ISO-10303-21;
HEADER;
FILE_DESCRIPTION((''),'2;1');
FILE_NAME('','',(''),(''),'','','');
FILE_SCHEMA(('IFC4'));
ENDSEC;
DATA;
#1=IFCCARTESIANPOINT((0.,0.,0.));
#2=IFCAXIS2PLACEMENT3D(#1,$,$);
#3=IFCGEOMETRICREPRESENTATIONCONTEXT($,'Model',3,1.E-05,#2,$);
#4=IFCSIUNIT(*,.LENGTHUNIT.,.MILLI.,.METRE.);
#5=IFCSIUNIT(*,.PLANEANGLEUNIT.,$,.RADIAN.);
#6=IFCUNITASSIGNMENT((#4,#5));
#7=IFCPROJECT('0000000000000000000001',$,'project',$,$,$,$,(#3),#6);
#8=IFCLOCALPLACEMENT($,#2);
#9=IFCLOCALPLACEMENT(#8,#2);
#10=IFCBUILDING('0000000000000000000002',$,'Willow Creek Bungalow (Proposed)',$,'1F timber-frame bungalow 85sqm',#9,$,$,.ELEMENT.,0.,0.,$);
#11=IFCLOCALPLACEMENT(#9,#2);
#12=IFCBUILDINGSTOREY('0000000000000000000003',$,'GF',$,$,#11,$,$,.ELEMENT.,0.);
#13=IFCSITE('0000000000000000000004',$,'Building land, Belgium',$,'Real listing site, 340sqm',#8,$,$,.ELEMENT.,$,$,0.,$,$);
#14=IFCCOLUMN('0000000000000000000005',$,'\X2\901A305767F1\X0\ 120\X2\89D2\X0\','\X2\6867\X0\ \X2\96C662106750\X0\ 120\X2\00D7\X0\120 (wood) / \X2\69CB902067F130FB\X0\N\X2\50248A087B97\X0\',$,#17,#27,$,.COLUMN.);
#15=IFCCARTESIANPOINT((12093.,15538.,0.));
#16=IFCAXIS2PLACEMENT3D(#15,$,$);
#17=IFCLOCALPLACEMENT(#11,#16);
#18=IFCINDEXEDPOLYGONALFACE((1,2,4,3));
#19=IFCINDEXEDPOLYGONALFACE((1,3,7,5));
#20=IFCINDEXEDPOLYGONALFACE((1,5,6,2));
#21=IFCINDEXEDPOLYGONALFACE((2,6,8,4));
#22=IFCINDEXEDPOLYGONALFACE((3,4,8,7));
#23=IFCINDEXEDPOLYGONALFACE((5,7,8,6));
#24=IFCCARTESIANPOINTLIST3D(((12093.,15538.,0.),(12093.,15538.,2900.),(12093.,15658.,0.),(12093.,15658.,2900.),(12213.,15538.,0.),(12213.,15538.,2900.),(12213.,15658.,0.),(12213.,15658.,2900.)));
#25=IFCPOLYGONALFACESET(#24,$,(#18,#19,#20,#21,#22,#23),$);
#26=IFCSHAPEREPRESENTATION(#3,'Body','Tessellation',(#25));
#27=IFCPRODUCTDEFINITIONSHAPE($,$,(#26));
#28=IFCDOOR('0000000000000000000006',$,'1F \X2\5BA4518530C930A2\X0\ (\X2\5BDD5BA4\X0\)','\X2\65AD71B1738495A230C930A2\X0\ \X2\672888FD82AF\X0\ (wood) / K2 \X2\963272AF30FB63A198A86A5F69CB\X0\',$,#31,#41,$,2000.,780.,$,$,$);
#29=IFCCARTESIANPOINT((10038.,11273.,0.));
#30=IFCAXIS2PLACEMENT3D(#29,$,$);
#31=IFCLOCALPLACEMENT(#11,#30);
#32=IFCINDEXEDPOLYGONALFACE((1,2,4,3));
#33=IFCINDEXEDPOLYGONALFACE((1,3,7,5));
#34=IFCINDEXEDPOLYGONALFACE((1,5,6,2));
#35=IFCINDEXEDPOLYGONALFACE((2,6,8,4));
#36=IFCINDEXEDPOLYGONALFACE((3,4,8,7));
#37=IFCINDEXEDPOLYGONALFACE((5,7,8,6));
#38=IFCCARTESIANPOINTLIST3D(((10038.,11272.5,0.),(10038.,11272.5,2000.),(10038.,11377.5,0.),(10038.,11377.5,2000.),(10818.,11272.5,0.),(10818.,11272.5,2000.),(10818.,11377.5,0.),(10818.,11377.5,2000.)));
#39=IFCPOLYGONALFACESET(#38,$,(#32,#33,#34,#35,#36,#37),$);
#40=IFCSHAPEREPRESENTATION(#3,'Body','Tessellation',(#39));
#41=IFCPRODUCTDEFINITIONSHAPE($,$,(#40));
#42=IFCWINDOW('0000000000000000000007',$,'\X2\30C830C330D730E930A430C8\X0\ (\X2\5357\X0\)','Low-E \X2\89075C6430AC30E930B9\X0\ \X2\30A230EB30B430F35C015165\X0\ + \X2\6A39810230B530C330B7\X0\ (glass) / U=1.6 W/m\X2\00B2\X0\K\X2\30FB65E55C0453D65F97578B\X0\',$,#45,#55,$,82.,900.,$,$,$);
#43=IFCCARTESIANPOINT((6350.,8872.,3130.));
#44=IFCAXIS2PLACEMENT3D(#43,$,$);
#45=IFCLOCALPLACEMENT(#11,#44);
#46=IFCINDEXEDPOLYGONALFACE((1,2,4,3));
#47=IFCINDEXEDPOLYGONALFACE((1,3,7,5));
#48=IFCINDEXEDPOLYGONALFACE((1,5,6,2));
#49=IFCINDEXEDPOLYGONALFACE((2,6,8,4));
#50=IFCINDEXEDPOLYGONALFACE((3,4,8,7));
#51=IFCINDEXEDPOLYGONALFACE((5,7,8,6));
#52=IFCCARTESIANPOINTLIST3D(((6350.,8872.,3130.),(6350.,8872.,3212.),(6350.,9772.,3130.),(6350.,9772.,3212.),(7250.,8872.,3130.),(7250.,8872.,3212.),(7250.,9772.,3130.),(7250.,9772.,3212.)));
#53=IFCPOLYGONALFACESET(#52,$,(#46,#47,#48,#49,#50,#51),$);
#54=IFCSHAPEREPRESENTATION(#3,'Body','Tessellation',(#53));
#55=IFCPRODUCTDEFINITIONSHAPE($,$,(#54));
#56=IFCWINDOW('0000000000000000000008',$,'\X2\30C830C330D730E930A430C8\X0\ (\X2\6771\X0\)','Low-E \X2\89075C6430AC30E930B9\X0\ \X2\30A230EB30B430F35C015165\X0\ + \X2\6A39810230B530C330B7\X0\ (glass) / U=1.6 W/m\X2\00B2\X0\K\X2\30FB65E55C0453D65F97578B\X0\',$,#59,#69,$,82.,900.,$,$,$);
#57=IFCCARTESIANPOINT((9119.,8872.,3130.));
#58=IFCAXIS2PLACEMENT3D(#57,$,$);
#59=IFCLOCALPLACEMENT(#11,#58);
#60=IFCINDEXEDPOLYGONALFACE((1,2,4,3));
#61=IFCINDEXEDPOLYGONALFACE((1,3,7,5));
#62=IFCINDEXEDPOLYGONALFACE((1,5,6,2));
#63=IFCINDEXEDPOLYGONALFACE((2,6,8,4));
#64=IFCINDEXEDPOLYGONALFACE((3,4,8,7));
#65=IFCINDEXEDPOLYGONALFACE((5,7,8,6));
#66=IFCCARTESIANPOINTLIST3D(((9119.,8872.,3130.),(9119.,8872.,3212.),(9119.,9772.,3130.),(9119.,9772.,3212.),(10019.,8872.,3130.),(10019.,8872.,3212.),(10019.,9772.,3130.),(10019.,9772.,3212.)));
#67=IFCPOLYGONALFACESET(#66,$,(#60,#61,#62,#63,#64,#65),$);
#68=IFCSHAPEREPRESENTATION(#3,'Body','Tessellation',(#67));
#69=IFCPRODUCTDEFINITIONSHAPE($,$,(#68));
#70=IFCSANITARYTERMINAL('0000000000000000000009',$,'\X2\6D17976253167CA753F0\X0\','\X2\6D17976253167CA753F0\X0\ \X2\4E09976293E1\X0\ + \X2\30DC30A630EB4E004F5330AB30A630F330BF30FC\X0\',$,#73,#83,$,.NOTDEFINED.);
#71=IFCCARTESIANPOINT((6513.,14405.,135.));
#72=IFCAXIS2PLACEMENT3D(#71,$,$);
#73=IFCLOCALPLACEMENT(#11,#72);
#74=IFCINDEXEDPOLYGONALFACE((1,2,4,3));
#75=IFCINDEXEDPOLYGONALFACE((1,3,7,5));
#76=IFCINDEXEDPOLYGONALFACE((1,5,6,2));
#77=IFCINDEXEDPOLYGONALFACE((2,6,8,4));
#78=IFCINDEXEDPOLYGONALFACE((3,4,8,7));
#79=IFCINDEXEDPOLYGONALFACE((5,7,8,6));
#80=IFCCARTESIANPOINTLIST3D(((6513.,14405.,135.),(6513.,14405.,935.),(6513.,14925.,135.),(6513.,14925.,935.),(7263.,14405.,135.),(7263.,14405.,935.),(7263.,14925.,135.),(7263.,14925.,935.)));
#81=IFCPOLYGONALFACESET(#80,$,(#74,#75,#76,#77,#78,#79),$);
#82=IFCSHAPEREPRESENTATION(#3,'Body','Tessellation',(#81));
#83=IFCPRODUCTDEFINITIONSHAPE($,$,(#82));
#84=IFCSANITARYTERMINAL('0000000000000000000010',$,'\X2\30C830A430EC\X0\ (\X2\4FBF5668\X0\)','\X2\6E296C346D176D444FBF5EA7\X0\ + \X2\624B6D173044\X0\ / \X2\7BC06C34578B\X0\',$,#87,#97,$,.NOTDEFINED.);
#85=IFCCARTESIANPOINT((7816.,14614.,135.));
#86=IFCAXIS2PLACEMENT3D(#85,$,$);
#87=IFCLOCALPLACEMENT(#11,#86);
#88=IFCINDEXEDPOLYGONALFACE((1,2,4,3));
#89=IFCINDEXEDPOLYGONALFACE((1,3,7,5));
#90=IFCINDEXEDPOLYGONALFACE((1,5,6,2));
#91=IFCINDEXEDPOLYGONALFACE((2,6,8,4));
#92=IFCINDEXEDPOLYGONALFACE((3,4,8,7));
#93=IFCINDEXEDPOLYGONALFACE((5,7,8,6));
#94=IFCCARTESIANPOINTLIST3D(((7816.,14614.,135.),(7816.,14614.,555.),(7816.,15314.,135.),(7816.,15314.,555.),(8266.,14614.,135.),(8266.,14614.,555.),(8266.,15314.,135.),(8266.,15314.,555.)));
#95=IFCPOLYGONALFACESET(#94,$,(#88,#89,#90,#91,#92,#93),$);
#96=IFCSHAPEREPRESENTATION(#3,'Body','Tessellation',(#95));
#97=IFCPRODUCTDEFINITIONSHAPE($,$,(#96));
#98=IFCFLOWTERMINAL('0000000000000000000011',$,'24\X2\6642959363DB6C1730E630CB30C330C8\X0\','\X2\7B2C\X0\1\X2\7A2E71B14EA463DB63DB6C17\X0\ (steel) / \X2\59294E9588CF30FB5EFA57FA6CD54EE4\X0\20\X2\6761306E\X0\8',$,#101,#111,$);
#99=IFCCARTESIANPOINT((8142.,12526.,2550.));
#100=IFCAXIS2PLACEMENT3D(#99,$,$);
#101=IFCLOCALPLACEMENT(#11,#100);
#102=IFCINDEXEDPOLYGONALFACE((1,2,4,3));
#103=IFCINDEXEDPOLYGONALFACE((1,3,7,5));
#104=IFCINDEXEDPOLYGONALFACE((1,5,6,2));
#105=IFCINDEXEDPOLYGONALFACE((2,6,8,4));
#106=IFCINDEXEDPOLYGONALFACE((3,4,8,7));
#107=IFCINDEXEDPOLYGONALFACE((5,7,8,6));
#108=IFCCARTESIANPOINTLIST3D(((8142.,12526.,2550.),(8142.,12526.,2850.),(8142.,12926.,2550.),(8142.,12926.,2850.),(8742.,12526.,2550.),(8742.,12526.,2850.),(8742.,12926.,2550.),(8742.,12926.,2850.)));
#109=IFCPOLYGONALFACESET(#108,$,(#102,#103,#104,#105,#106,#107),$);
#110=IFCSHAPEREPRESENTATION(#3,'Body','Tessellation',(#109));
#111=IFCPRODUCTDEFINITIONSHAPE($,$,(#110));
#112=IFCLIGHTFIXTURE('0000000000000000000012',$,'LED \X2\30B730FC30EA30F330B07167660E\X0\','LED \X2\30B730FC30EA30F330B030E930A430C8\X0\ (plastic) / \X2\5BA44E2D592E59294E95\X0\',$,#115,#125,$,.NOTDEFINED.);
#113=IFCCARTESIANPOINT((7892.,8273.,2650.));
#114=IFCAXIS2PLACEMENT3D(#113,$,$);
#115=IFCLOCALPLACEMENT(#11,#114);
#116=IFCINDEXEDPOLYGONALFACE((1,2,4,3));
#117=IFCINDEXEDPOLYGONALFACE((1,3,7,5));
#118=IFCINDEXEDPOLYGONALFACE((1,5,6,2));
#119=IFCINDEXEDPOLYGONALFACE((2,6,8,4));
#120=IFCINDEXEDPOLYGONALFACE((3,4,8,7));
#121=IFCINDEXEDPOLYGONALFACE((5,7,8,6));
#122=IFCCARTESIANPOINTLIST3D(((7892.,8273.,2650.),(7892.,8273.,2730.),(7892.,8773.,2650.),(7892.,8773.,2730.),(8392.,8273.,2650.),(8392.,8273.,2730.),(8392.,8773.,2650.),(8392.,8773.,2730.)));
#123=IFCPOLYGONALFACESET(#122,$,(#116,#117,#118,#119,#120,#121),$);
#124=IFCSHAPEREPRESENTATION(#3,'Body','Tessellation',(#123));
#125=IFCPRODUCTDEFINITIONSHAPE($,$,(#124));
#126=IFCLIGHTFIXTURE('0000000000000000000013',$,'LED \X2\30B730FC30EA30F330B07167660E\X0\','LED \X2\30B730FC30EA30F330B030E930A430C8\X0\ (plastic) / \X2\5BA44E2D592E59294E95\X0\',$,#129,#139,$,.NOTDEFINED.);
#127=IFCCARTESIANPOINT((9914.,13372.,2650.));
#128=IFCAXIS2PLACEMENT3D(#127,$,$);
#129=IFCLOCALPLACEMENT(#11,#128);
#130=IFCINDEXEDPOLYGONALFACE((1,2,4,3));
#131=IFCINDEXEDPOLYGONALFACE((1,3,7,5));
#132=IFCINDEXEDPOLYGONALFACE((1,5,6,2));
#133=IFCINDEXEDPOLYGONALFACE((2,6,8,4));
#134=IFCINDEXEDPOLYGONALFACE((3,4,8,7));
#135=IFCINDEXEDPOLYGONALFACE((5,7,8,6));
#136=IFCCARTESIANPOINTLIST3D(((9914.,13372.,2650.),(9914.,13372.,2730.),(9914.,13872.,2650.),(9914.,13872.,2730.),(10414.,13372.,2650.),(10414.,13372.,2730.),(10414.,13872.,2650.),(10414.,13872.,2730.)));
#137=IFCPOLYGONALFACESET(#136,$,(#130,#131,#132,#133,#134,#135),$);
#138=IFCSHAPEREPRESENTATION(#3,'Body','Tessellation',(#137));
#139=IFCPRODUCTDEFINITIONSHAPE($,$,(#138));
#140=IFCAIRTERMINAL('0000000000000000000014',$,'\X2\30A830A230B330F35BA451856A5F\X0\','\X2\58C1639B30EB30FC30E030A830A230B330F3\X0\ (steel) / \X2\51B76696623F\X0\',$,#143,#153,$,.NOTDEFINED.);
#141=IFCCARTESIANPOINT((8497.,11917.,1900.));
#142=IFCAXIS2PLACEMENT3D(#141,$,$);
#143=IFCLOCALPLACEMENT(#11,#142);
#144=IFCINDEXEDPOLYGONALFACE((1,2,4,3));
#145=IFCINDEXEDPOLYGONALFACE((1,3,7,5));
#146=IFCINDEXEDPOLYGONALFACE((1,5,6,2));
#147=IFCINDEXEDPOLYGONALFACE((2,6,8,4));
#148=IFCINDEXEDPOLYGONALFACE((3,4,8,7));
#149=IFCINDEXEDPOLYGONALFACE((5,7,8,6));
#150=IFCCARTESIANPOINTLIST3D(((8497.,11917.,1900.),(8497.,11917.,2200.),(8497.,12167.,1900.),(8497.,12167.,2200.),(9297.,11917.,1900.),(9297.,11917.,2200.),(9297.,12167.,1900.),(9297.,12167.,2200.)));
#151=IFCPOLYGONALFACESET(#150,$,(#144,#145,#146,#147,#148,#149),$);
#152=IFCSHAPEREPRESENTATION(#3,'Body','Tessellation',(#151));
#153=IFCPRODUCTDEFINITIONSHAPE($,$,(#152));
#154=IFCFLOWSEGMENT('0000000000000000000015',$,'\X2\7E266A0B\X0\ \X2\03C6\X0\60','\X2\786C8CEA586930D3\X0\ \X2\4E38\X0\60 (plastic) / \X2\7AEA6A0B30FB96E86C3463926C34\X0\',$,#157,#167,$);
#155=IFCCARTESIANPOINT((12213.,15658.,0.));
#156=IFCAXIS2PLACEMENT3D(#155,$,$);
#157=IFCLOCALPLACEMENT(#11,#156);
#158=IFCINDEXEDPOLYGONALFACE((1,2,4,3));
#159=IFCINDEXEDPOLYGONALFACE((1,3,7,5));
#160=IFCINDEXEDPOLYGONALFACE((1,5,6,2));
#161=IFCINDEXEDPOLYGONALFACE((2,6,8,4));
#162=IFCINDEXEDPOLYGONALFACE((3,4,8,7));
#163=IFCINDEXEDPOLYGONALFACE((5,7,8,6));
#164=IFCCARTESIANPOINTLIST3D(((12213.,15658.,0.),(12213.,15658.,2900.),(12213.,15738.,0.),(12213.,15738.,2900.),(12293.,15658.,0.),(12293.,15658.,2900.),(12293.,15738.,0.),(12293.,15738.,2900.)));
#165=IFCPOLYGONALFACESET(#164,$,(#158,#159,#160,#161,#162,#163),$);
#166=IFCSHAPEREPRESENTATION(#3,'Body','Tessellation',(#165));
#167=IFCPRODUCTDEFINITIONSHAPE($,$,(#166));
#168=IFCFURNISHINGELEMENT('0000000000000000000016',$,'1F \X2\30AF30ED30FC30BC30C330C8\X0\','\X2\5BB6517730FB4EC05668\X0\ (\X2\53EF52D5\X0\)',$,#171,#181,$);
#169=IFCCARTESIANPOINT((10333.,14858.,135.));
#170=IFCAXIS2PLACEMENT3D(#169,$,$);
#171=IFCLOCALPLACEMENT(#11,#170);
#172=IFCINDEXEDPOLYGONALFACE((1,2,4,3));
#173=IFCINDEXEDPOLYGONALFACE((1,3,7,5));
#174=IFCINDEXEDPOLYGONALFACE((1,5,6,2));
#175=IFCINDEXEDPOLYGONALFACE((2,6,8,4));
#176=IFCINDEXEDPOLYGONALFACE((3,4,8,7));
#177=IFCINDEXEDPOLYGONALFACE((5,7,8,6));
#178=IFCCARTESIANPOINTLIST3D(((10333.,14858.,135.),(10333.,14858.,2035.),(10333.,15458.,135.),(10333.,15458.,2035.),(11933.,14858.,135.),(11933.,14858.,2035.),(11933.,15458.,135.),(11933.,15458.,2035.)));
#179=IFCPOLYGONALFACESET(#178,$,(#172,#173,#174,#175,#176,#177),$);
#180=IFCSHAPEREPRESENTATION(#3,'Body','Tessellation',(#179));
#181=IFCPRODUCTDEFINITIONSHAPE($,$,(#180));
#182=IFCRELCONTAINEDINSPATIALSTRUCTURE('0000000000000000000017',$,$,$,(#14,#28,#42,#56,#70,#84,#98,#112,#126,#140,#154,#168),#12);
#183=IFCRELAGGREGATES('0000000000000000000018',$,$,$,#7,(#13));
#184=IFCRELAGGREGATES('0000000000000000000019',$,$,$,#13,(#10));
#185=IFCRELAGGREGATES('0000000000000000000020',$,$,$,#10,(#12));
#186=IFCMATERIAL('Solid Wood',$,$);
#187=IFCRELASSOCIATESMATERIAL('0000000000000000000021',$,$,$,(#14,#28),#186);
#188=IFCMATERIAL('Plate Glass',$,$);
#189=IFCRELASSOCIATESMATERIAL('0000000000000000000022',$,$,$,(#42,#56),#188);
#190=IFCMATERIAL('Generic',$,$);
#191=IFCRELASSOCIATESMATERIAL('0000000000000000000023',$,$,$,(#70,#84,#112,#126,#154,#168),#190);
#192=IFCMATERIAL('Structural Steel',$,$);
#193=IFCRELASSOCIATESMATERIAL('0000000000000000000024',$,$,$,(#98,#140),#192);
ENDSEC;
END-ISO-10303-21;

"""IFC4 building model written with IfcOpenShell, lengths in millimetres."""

from ifc_helpers import new_model, si_unit, frame, frame_2d, origin, place, context, project, spatial, rectangle, extrude, material, element, save


model = new_model("IFC4")

# Units and contexts
model_context = context("Model", 3, precision=1e-05, world=origin())
ifc_project = project(units=[si_unit("LENGTHUNIT", "METRE", prefix="MILLI"), si_unit("PLANEANGLEUNIT", "RADIAN")], contexts=[model_context])

# Site, building, storey
site_placement = place(None, origin())
site = spatial("IfcSite", under=ifc_project, at=site_placement, Name="Building land, Belgium", ObjectType="Real listing site, 340sqm", CompositionType="ELEMENT", RefElevation=0.0)
building_placement = place(site_placement, origin())
building = spatial("IfcBuilding", under=site, at=building_placement, Name="Willow Creek Bungalow (Proposed)", ObjectType="1F timber-frame bungalow 85sqm", CompositionType="ELEMENT", ElevationOfRefHeight=0.0, ElevationOfTerrain=0.0)
storey_placement = place(building_placement, origin())
storey = spatial("IfcBuildingStorey", under=building, at=storey_placement, Name="GF", CompositionType="ELEMENT", Elevation=0.0)

# Column
ifc_material_1 = material(Name="Solid Wood")
column_1_placement = place(storey_placement, frame((12093.0, 15538.0, 0.0)))
element("IfcColumn", 1, at=column_1_placement, inside=storey, material=ifc_material_1, Name="通し柱 120角", Description="桧 集成材 120×120 (wood) / 構造柱・N値計算", PredefinedType="COLUMN", context=model_context, shape_type="SweptSolid", body=[
    extrude(rectangle(XDim=120.0, YDim=120.0, at=frame_2d((60.0, 60.0))), frame((12093.0, 15538.0, 0.0)), (0.0, 0.0, 1.0), 2900.0),
])

# Door
door_placement = place(storey_placement, frame((10038.0, 11273.0, 0.0)))
element("IfcDoor", 2, at=door_placement, inside=storey, material=ifc_material_1, Name="1F 室内ドア (寝室)", Description="断熱玄関ドア 木製芯 (wood) / K2 防犯・採風機構", OverallHeight=2000.0, OverallWidth=780.0, context=model_context, shape_type="SweptSolid", body=[
    extrude(rectangle(XDim=780.0, YDim=105.0, at=frame_2d((390.0, 52.0))), frame((10038.0, 11273.0, 0.0)), (0.0, 0.0, 1.0), 2000.0),
])

# Windows
ifc_material_2 = material(Name="Plate Glass")
window_1_placement = place(storey_placement, frame((6350.0, 8872.0, 3130.0)))
element("IfcWindow", 3, at=window_1_placement, inside=storey, material=ifc_material_2, Name="トップライト (南)", Description="Low-E 複層ガラス アルゴン封入 + 樹脂サッシ (glass) / U=1.6 W/m²K・日射取得型", OverallHeight=82.0, OverallWidth=900.0, context=model_context, shape_type="SweptSolid", body=[
    extrude(rectangle(XDim=900.0, YDim=900.0, at=frame_2d((450.0, 450.0))), frame((6350.0, 8872.0, 3130.0)), (0.0, 0.0, 1.0), 82.0),
])
window_2_placement = place(storey_placement, frame((9119.0, 8872.0, 3130.0)))
element("IfcWindow", 4, at=window_2_placement, inside=storey, material=ifc_material_2, Name="トップライト (東)", Description="Low-E 複層ガラス アルゴン封入 + 樹脂サッシ (glass) / U=1.6 W/m²K・日射取得型", OverallHeight=82.0, OverallWidth=900.0, context=model_context, shape_type="SweptSolid", body=[
    extrude(rectangle(XDim=900.0, YDim=900.0, at=frame_2d((450.0, 450.0))), frame((9119.0, 8872.0, 3130.0)), (0.0, 0.0, 1.0), 82.0),
])

# Sanitary terminals
ifc_material_3 = material(Name="Generic")
sanitary_terminal_1_placement = place(storey_placement, frame((6513.0, 14405.0, 135.0)))
element("IfcSanitaryTerminal", 5, at=sanitary_terminal_1_placement, inside=storey, material=ifc_material_3, Name="洗面化粧台", Description="洗面化粧台 三面鏡 + ボウル一体カウンター", PredefinedType="NOTDEFINED", context=model_context, shape_type="SweptSolid", body=[
    extrude(rectangle(XDim=750.0, YDim=520.0, at=frame_2d((375.0, 260.0))), frame((6513.0, 14405.0, 135.0)), (0.0, 0.0, 1.0), 800.0),
])
sanitary_terminal_2_placement = place(storey_placement, frame((7816.0, 14614.0, 135.0)))
element("IfcSanitaryTerminal", 6, at=sanitary_terminal_2_placement, inside=storey, material=ifc_material_3, Name="トイレ (便器)", Description="温水洗浄便座 + 手洗い / 節水型", PredefinedType="NOTDEFINED", context=model_context, shape_type="SweptSolid", body=[
    extrude(rectangle(XDim=450.0, YDim=700.0, at=frame_2d((225.0, 350.0))), frame((7816.0, 14614.0, 135.0)), (0.0, 0.0, 1.0), 420.0),
])

# Flow terminal
ifc_material_4 = material(Name="Structural Steel")
flow_terminal_placement = place(storey_placement, frame((8142.0, 12526.0, 2550.0)))
element("IfcFlowTerminal", 7, at=flow_terminal_placement, inside=storey, material=ifc_material_4, Name="24時間換気ユニット", Description="第1種熱交換換気 (steel) / 天井裏・建基法令20条の8", context=model_context, shape_type="SweptSolid", body=[
    extrude(rectangle(XDim=600.0, YDim=400.0, at=frame_2d((300.0, 200.0))), frame((8142.0, 12526.0, 2550.0)), (0.0, 0.0, 1.0), 300.0),
])

# Light fixtures
light_fixture_1_placement = place(storey_placement, frame((7892.0, 8273.0, 2650.0)))
element("IfcLightFixture", 8, at=light_fixture_1_placement, inside=storey, material=ifc_material_3, Name="LED シーリング照明", Description="LED シーリングライト (plastic) / 室中央天井", PredefinedType="NOTDEFINED", context=model_context, shape_type="SweptSolid", body=[
    extrude(rectangle(XDim=500.0, YDim=500.0, at=frame_2d((250.0, 250.0))), frame((7892.0, 8273.0, 2650.0)), (0.0, 0.0, 1.0), 80.0),
])
light_fixture_2_placement = place(storey_placement, frame((9914.0, 13372.0, 2650.0)))
element("IfcLightFixture", 9, at=light_fixture_2_placement, inside=storey, material=ifc_material_3, Name="LED シーリング照明", Description="LED シーリングライト (plastic) / 室中央天井", PredefinedType="NOTDEFINED", context=model_context, shape_type="SweptSolid", body=[
    extrude(rectangle(XDim=500.0, YDim=500.0, at=frame_2d((250.0, 250.0))), frame((9914.0, 13372.0, 2650.0)), (0.0, 0.0, 1.0), 80.0),
])

# Air terminal
air_terminal_placement = place(storey_placement, frame((8497.0, 11917.0, 1900.0)))
element("IfcAirTerminal", 10, at=air_terminal_placement, inside=storey, material=ifc_material_4, Name="エアコン室内機", Description="壁掛ルームエアコン (steel) / 冷暖房", PredefinedType="NOTDEFINED", context=model_context, shape_type="SweptSolid", body=[
    extrude(rectangle(XDim=800.0, YDim=250.0, at=frame_2d((400.0, 125.0))), frame((8497.0, 11917.0, 1900.0)), (0.0, 0.0, 1.0), 300.0),
])

# Flow segment
flow_segment_placement = place(storey_placement, frame((12213.0, 15658.0, 0.0)))
element("IfcFlowSegment", 11, at=flow_segment_placement, inside=storey, material=ifc_material_3, Name="縦樋 φ60", Description="硬質塩ビ 丸60 (plastic) / 竪樋・雨水排水", context=model_context, shape_type="SweptSolid", body=[
    extrude(rectangle(XDim=80.0, YDim=80.0, at=frame_2d((40.0, 40.0))), frame((12213.0, 15658.0, 0.0)), (0.0, 0.0, 1.0), 2900.0),
])

# Furnishing element
furnishing_placement = place(storey_placement, frame((10333.0, 14858.0, 135.0)))
element("IfcFurnishingElement", 12, at=furnishing_placement, inside=storey, material=ifc_material_3, Name="1F クローゼット", Description="家具・什器 (可動)", context=model_context, shape_type="SweptSolid", body=[
    extrude(rectangle(XDim=1600.0, YDim=600.0, at=frame_2d((800.0, 300.0))), frame((10333.0, 14858.0, 135.0)), (0.0, 0.0, 1.0), 1900.0),
])

save(model, "model.ifc")
